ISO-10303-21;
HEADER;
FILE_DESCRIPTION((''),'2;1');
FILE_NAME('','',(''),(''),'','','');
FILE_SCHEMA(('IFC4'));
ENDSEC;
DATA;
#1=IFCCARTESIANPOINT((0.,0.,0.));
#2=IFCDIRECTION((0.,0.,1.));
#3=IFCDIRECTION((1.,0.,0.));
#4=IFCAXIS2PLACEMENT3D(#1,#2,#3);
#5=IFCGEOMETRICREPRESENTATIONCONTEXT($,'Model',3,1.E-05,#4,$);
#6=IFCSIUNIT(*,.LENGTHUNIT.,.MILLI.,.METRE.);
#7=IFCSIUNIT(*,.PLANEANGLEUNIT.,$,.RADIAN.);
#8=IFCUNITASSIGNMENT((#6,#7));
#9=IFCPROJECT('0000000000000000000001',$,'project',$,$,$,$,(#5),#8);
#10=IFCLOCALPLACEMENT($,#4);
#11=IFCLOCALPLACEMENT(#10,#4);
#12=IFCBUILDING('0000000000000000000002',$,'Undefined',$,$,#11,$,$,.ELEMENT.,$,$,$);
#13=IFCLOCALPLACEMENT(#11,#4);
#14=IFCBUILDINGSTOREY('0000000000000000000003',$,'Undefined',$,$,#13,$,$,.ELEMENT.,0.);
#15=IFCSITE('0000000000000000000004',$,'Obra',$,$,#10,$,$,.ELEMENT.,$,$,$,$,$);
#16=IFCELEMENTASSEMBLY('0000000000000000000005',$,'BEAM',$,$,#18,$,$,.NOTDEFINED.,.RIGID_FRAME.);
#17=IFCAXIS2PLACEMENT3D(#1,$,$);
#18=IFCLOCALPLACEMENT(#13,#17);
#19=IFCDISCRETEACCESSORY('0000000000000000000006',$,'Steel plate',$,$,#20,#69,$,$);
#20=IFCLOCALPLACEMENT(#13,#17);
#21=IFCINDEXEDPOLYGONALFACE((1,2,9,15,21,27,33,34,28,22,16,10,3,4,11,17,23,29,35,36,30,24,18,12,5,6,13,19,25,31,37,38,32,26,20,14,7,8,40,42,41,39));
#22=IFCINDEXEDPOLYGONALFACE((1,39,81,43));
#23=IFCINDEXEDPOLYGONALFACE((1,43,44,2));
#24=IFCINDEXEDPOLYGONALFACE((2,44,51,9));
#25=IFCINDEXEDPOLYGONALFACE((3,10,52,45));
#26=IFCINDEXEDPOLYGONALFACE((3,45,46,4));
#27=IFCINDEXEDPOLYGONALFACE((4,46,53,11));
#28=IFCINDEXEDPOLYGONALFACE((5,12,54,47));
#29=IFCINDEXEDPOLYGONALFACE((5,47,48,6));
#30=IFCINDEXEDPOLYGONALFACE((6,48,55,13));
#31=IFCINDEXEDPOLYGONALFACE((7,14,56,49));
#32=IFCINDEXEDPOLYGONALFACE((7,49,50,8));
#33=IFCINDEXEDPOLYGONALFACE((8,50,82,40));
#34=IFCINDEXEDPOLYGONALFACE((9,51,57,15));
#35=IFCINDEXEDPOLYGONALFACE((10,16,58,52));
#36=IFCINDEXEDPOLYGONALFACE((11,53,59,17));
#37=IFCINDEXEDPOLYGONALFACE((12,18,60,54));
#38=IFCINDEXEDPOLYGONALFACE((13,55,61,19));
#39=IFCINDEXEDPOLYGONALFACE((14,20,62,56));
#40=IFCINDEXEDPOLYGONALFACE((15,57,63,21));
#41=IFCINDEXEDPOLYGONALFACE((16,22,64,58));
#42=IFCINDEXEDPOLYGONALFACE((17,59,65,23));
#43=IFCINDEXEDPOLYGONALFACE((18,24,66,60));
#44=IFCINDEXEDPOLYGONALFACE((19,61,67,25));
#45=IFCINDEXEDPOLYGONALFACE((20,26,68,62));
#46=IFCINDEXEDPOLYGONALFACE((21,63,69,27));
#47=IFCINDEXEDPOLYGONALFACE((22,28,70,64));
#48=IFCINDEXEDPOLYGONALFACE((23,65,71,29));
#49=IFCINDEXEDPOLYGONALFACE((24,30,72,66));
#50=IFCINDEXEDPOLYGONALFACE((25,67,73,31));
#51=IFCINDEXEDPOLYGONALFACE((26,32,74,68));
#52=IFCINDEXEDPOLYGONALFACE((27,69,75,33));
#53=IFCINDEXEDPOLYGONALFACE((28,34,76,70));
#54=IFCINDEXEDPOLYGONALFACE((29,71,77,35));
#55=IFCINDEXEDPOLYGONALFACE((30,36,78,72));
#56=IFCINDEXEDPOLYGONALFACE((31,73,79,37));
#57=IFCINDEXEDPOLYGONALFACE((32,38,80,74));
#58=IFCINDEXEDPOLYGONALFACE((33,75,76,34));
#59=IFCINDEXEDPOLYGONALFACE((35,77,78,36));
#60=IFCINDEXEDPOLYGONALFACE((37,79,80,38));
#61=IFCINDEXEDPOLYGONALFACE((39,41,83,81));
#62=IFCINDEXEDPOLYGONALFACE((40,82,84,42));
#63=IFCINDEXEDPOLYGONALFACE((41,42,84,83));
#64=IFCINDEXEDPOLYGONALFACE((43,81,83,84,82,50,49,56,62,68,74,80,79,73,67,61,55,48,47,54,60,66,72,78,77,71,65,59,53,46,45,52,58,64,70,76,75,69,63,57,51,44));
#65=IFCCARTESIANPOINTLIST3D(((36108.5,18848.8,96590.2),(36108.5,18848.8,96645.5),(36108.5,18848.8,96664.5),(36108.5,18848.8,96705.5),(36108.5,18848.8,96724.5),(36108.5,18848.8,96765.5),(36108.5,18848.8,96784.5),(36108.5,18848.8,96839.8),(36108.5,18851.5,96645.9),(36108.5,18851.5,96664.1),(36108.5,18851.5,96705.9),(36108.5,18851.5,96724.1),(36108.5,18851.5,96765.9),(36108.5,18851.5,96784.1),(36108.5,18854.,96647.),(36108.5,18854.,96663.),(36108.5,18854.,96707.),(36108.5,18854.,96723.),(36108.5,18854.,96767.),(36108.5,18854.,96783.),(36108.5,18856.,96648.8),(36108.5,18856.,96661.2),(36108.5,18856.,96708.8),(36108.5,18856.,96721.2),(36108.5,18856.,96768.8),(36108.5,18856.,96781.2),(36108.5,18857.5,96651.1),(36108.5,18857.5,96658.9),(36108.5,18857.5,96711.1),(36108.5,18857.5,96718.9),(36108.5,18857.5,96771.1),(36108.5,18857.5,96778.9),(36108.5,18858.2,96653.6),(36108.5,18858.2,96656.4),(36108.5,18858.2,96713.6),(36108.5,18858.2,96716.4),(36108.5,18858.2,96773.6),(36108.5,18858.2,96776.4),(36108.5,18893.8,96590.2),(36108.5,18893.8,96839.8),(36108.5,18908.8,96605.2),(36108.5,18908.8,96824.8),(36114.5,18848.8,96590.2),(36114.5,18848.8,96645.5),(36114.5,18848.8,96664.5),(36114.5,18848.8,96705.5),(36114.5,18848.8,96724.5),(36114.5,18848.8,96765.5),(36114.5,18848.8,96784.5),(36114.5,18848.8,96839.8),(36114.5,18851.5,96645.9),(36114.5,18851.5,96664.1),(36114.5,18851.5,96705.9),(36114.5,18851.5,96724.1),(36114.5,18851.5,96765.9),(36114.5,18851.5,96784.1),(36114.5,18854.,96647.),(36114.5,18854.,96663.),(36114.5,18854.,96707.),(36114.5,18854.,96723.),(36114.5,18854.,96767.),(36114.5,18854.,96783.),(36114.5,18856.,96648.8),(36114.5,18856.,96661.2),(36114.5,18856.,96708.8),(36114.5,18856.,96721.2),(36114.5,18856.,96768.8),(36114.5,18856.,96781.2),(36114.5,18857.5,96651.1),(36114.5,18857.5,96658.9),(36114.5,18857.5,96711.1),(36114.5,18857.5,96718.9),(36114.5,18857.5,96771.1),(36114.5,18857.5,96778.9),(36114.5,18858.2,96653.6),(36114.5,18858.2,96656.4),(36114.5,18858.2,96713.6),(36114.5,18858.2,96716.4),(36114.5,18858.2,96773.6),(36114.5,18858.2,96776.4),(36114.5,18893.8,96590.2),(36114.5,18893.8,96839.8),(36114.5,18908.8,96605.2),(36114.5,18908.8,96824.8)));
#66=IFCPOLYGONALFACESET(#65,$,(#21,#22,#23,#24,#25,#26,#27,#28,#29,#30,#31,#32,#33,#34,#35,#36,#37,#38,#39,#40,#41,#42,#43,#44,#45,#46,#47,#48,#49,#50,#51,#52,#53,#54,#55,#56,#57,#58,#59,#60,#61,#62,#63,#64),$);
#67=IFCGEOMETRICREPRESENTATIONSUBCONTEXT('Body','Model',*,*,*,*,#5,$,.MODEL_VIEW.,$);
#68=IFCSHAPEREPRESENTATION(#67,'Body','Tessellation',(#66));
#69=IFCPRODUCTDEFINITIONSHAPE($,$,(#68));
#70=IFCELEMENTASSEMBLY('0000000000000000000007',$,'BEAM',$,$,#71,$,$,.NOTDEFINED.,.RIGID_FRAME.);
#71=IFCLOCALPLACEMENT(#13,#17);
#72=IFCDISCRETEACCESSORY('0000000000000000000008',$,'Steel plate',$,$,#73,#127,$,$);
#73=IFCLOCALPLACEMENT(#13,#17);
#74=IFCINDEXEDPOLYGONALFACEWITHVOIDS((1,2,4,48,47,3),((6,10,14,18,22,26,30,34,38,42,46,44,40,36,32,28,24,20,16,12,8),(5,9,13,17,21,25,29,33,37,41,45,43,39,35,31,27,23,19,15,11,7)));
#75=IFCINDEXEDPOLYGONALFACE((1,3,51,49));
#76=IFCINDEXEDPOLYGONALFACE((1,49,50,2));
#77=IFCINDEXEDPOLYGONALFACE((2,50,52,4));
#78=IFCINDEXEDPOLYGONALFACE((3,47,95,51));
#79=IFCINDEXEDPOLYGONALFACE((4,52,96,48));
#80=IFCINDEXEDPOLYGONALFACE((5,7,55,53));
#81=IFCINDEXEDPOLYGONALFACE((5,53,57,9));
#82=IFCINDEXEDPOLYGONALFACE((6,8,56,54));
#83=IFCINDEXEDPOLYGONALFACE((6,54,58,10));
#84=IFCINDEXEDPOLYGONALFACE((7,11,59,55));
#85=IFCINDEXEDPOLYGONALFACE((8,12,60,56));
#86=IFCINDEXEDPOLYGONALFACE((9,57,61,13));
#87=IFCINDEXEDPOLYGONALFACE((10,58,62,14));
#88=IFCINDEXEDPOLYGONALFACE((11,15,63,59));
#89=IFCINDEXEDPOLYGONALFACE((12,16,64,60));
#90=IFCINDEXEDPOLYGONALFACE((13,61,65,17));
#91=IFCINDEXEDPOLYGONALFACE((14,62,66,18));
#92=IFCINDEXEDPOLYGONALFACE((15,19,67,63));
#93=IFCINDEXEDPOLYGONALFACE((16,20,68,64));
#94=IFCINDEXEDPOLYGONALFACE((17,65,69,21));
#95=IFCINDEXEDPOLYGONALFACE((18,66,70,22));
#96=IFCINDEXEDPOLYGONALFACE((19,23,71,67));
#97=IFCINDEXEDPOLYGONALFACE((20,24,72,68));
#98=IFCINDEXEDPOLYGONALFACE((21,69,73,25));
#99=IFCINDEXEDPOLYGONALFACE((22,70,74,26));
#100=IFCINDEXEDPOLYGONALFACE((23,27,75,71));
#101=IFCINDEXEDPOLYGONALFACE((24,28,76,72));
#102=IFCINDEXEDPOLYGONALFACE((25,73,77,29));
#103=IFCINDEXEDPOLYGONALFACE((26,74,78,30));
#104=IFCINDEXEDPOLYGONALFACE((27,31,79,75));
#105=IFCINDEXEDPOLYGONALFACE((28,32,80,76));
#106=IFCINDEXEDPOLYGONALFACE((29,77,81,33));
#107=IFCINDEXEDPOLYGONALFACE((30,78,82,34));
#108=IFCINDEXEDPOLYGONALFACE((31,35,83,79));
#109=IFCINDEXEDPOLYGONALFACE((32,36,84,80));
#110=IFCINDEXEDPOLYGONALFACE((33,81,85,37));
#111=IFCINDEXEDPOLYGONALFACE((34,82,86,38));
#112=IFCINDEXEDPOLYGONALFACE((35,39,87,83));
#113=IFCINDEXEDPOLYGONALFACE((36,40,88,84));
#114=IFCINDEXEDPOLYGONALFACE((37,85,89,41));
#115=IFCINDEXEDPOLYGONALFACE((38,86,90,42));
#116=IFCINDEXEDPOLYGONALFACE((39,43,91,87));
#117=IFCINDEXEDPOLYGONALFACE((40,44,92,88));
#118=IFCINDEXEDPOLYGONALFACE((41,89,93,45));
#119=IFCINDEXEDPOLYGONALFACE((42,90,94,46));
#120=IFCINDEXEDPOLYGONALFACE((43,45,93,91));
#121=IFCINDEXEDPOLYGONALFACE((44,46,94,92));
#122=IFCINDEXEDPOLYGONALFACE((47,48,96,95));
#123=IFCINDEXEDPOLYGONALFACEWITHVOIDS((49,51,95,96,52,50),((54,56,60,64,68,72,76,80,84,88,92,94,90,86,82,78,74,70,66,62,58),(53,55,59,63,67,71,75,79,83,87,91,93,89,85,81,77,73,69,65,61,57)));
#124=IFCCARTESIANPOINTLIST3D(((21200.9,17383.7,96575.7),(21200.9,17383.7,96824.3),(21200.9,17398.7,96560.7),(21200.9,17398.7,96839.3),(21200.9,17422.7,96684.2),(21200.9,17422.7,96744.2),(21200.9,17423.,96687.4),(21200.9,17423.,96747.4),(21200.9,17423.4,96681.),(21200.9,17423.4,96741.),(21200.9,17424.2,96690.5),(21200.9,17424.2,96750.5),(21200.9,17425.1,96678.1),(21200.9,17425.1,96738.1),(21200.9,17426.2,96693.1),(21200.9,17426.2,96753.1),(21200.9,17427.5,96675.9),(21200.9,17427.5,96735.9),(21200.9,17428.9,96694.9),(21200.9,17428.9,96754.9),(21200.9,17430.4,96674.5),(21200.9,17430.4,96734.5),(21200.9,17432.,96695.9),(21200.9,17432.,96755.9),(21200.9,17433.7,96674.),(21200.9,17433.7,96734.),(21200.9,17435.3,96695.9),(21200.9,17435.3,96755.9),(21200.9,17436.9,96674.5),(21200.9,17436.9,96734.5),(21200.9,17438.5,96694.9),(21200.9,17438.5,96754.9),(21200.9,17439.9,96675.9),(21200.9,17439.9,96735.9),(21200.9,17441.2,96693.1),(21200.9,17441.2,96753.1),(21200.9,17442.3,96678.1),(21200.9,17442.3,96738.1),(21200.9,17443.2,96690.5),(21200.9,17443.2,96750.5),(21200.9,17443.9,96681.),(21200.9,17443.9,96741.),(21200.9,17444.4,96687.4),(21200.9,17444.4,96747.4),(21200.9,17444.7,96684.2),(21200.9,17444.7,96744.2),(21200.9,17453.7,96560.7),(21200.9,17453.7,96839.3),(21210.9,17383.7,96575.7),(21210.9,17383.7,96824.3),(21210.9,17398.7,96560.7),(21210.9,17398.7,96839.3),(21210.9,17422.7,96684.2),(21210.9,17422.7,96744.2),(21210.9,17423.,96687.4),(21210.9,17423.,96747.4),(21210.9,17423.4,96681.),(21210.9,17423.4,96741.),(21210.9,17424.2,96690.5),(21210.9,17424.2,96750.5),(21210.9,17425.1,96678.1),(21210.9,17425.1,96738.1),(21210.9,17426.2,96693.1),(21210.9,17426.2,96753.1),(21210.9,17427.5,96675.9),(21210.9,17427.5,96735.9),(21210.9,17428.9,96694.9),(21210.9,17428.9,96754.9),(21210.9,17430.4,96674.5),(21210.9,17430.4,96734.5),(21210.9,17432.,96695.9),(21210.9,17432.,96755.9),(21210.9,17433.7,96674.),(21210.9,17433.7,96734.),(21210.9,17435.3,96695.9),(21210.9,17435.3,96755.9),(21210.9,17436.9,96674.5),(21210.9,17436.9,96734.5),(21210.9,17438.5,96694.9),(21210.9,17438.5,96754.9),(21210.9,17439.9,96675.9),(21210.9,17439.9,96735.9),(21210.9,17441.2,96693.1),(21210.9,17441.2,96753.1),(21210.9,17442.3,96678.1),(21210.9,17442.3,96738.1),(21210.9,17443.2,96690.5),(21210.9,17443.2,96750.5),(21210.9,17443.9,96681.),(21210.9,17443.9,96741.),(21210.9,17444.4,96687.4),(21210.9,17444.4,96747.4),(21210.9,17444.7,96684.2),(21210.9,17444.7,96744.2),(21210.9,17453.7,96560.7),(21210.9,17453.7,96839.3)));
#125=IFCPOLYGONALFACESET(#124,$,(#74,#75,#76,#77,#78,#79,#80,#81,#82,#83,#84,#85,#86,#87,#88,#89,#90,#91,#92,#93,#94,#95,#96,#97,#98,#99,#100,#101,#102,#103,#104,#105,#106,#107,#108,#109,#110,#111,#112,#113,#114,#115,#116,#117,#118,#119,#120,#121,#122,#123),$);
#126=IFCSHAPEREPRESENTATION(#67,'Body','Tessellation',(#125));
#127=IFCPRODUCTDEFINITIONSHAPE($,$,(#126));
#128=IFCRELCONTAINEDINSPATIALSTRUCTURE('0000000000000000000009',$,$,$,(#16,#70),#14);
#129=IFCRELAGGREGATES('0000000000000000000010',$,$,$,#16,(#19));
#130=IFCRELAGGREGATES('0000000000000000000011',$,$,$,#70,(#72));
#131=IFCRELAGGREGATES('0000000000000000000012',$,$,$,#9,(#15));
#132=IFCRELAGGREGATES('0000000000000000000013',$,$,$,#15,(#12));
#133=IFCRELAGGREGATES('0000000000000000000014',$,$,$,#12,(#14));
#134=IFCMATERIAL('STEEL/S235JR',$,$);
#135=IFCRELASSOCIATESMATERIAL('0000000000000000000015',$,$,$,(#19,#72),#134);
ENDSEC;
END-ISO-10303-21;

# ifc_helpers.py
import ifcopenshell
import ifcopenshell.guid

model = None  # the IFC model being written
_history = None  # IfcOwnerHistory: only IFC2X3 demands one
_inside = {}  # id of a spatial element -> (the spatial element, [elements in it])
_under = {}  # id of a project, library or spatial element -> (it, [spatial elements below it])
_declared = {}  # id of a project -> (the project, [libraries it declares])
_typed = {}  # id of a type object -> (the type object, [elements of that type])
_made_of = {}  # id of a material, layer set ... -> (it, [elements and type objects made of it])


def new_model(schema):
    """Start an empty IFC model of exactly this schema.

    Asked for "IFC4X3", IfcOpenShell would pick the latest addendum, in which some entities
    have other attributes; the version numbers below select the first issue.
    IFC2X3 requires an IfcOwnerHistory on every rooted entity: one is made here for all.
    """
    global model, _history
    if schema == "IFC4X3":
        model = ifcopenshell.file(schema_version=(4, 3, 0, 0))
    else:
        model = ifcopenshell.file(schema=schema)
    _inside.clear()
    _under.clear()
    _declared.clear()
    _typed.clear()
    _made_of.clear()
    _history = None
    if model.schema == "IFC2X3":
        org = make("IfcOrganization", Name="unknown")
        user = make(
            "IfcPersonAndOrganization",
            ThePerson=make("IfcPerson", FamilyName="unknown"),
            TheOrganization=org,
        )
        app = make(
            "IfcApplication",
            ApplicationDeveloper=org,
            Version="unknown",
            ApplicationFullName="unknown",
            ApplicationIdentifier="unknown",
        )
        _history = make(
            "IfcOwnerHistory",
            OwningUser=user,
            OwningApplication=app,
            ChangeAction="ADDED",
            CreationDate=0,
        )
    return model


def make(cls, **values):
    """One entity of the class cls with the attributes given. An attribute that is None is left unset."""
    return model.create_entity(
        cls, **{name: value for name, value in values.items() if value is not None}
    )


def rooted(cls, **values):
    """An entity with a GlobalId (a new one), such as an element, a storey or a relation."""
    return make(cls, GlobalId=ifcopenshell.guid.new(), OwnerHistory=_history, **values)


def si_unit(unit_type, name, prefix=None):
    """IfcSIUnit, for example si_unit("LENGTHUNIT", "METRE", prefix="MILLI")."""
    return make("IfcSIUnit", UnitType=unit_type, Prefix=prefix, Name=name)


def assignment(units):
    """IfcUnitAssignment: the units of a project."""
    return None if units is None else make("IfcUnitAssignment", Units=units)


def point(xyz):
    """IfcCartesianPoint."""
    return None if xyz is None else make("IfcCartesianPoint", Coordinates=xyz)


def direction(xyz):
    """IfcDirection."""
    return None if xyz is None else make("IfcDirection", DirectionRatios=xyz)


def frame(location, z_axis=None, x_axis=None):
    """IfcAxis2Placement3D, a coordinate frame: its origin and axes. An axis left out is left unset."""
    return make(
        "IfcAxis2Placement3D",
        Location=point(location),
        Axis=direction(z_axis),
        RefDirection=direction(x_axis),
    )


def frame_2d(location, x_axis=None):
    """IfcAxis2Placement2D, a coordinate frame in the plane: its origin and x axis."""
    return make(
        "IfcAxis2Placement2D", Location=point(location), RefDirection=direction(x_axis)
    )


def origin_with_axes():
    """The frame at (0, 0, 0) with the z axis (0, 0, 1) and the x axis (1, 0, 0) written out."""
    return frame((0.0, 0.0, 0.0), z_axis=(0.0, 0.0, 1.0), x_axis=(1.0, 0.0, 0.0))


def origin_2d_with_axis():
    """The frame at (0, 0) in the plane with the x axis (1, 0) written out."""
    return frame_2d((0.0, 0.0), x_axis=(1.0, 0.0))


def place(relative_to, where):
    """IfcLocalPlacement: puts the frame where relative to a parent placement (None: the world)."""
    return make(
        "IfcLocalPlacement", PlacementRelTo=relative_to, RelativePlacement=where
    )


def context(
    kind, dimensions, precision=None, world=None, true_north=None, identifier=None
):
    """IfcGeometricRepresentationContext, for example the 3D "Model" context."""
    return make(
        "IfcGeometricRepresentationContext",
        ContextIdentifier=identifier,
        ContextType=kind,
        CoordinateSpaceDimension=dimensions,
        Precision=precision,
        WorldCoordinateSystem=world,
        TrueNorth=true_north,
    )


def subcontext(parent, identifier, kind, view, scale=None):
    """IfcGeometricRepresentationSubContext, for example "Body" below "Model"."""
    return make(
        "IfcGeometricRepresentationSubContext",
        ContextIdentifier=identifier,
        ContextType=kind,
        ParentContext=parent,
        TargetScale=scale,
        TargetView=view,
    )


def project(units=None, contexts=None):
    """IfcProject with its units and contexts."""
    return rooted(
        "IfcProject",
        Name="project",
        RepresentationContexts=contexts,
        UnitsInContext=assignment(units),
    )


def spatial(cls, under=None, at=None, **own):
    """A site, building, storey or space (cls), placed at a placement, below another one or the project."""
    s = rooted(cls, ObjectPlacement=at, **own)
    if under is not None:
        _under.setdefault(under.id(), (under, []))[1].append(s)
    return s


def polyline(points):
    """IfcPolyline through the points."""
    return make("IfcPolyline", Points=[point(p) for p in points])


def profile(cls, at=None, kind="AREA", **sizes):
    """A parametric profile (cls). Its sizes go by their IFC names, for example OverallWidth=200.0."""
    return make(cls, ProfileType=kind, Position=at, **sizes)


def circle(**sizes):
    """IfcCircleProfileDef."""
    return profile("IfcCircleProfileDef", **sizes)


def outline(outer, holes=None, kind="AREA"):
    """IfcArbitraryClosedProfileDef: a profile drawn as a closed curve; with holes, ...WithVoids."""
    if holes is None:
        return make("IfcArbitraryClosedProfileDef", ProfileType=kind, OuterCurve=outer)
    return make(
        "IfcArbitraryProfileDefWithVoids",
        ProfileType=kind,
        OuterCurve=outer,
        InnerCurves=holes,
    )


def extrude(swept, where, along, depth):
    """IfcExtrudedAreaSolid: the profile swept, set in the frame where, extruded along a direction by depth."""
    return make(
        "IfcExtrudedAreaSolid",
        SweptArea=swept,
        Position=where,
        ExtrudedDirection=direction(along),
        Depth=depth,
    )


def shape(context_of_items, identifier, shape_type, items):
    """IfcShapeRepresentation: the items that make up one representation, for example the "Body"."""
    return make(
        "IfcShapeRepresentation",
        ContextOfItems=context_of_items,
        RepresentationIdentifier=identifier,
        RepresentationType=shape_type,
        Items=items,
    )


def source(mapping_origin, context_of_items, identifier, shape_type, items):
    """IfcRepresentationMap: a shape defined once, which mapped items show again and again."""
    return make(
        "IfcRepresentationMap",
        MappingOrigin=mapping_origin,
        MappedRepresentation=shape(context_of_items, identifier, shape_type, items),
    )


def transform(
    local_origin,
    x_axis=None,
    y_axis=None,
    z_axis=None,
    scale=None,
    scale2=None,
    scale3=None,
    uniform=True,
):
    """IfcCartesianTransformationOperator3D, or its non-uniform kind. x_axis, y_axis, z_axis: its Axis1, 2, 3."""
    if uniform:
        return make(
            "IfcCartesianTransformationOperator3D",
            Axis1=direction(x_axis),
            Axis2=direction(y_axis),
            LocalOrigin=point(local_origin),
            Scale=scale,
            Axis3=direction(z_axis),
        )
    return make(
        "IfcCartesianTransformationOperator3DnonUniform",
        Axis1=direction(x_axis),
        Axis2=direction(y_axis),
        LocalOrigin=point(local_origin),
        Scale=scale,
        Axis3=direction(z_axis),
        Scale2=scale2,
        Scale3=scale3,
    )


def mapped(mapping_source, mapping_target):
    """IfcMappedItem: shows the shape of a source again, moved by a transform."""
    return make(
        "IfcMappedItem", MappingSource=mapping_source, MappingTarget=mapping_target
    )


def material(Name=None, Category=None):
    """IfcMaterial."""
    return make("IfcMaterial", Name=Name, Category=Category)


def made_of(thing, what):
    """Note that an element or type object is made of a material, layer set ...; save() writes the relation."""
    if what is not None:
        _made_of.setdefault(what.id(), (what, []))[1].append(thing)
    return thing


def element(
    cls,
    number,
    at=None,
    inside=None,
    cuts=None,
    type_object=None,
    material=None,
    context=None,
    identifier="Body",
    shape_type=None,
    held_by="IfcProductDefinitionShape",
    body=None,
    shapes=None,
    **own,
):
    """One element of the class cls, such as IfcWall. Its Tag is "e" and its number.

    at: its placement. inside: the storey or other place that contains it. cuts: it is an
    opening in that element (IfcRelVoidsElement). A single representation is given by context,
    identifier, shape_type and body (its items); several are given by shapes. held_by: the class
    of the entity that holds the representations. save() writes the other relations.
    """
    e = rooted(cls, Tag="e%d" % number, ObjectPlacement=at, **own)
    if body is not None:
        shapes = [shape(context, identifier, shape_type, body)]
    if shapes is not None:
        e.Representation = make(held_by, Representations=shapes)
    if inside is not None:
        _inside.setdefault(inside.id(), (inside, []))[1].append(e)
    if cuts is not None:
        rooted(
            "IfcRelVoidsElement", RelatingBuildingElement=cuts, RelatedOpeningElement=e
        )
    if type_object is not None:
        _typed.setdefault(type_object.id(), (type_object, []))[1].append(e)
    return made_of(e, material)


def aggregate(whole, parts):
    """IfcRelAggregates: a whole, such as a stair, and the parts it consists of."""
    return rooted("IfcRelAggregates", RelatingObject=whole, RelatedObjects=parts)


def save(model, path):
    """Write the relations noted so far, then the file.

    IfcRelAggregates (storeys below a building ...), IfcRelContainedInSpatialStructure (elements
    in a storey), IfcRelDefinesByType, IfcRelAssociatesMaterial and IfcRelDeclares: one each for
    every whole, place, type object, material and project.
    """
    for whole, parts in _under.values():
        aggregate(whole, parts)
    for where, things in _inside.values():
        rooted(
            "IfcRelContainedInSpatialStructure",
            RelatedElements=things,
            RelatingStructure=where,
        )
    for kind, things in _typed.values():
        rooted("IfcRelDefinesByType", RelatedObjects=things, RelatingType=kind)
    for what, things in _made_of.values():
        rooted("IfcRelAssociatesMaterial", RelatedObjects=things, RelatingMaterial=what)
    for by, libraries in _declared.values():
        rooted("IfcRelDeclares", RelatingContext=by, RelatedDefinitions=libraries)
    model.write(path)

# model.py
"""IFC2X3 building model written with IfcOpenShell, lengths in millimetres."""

from ifc_helpers import new_model, si_unit, frame, origin_with_axes, origin_2d_with_axis, place, context, subcontext, project, spatial, polyline, circle, outline, extrude, source, transform, mapped, material, element, aggregate, save


model = new_model("IFC2X3")

# Units and contexts
model_context = context("Model", 3, precision=1e-05, world=origin_with_axes())
body_context = subcontext(model_context, "Body", "Model", "MODEL_VIEW")
ifc_project = project(units=[si_unit("LENGTHUNIT", "METRE", prefix="MILLI"), si_unit("PLANEANGLEUNIT", "RADIAN")], contexts=[model_context])

# Site, building, storey
site_placement = place(None, origin_with_axes())
site = spatial("IfcSite", under=ifc_project, at=site_placement, Name="Obra", CompositionType="ELEMENT")
building_placement = place(site_placement, origin_with_axes())
building = spatial("IfcBuilding", under=site, at=building_placement, Name="Undefined", CompositionType="ELEMENT")
storey_placement = place(building_placement, origin_with_axes())
storey = spatial("IfcBuildingStorey", under=building, at=storey_placement, Name="Undefined", CompositionType="ELEMENT", Elevation=0.0)

# Shared definitions
ifc_material = material(Name="STEEL/S235JR")

# Shared definitions
shared_shape_1 = source(origin_with_axes(), body_context, "Body", "SweptSolid", [
    extrude(circle(Radius=9.5, at=origin_2d_with_axis()), frame((0.0, -9.4, 0.0), z_axis=(0.0, 1.0, 0.0), x_axis=(1.0, 0.0, 0.0)), (0.0, 0.0, 1.0), 6.2),
])

# Shared definitions
shared_shape_2 = source(origin_with_axes(), body_context, "Body", "SweptSolid", [
    extrude(circle(Radius=11.0, at=origin_2d_with_axis()), frame((0.0, -13.4, 0.0), z_axis=(0.0, 1.0, 0.0), x_axis=(1.0, 0.0, 0.0)), (0.0, 0.0, 1.0), 10.2),
])

# Element assembly, discrete accessory, opening
assembly_1_placement = place(storey_placement, origin_with_axes())
assembly_1 = element("IfcElementAssembly", 1, at=assembly_1_placement, inside=storey, Name="BEAM", AssemblyPlace="NOTDEFINED", PredefinedType="RIGID_FRAME")
discrete_accessory_1_placement = place(assembly_1_placement, frame((36111.5, 18848.8, 96590.2), z_axis=(1.0, 0.0, 0.0), x_axis=(0.0, 1.0, 0.0)))
discrete_accessory_1 = element("IfcDiscreteAccessory", 2, at=discrete_accessory_1_placement, material=ifc_material, Name="Steel plate", context=body_context, shape_type="SweptSolid", body=[
    extrude(outline(polyline([(0.0, 0.0), (45.0, 0.0), (60.0, 15.0), (60.0, 234.6), (45.0, 249.6), (0.0, 249.6), (0.0, 0.0)])), frame((0.0, 0.0, -3.0), z_axis=(0.0, 0.0, 1.0), x_axis=(1.0, 0.0, 0.0)), (0.0, 0.0, 1.0), 6.0),
])
opening_1_placement = place(assembly_1_placement, frame((36117.8, 18898.8, 96850.0), z_axis=(0.0, -1.0, 0.0), x_axis=(0.0, 0.0, -1.0)))
element("IfcOpeningElement", 3, at=opening_1_placement, cuts=discrete_accessory_1, ObjectType="Opening", context=body_context, shape_type="MappedRepresentation", body=[
    mapped(shared_shape_1, transform((75.0, 0.0, 50.0))),
    mapped(shared_shape_1, transform((135.0, 0.0, 50.0))),
    mapped(shared_shape_1, transform((195.0, 0.0, 50.0))),
])
aggregate(assembly_1, [discrete_accessory_1])

# Element assembly, discrete accessory, opening
assembly_2_placement = place(storey_placement, origin_with_axes())
assembly_2 = element("IfcElementAssembly", 4, at=assembly_2_placement, inside=storey, Name="BEAM", AssemblyPlace="NOTDEFINED", PredefinedType="RIGID_FRAME")
discrete_accessory_2_placement = place(assembly_2_placement, frame((21205.9, 17453.7, 96560.7), z_axis=(-1.0, 0.0, 0.0), x_axis=(0.0, -1.0, 0.0)))
discrete_accessory_2 = element("IfcDiscreteAccessory", 5, at=discrete_accessory_2_placement, material=ifc_material, Name="Steel plate", context=body_context, shape_type="SweptSolid", body=[
    extrude(outline(polyline([(0.0, 0.0), (55.0, 0.0), (70.0, 15.0), (70.0, 263.6), (55.0, 278.6), (0.0, 278.6), (0.0, 0.0)])), frame((0.0, 0.0, -5.0), z_axis=(0.0, 0.0, 1.0), x_axis=(1.0, 0.0, 0.0)), (0.0, 0.0, 1.0), 10.0),
])
opening_2_placement = place(assembly_2_placement, frame((21197.6, 17393.7, 96850.0), z_axis=(0.0, 1.0, 0.0), x_axis=(0.0, 0.0, -1.0)))
element("IfcOpeningElement", 6, at=opening_2_placement, cuts=discrete_accessory_2, ObjectType="Opening", context=body_context, shape_type="MappedRepresentation", body=[
    mapped(shared_shape_2, transform((105.0, 0.0, 40.0))),
    mapped(shared_shape_2, transform((165.0, 0.0, 40.0))),
])

aggregate(assembly_2, [discrete_accessory_2])

save(model, "model.ifc")
